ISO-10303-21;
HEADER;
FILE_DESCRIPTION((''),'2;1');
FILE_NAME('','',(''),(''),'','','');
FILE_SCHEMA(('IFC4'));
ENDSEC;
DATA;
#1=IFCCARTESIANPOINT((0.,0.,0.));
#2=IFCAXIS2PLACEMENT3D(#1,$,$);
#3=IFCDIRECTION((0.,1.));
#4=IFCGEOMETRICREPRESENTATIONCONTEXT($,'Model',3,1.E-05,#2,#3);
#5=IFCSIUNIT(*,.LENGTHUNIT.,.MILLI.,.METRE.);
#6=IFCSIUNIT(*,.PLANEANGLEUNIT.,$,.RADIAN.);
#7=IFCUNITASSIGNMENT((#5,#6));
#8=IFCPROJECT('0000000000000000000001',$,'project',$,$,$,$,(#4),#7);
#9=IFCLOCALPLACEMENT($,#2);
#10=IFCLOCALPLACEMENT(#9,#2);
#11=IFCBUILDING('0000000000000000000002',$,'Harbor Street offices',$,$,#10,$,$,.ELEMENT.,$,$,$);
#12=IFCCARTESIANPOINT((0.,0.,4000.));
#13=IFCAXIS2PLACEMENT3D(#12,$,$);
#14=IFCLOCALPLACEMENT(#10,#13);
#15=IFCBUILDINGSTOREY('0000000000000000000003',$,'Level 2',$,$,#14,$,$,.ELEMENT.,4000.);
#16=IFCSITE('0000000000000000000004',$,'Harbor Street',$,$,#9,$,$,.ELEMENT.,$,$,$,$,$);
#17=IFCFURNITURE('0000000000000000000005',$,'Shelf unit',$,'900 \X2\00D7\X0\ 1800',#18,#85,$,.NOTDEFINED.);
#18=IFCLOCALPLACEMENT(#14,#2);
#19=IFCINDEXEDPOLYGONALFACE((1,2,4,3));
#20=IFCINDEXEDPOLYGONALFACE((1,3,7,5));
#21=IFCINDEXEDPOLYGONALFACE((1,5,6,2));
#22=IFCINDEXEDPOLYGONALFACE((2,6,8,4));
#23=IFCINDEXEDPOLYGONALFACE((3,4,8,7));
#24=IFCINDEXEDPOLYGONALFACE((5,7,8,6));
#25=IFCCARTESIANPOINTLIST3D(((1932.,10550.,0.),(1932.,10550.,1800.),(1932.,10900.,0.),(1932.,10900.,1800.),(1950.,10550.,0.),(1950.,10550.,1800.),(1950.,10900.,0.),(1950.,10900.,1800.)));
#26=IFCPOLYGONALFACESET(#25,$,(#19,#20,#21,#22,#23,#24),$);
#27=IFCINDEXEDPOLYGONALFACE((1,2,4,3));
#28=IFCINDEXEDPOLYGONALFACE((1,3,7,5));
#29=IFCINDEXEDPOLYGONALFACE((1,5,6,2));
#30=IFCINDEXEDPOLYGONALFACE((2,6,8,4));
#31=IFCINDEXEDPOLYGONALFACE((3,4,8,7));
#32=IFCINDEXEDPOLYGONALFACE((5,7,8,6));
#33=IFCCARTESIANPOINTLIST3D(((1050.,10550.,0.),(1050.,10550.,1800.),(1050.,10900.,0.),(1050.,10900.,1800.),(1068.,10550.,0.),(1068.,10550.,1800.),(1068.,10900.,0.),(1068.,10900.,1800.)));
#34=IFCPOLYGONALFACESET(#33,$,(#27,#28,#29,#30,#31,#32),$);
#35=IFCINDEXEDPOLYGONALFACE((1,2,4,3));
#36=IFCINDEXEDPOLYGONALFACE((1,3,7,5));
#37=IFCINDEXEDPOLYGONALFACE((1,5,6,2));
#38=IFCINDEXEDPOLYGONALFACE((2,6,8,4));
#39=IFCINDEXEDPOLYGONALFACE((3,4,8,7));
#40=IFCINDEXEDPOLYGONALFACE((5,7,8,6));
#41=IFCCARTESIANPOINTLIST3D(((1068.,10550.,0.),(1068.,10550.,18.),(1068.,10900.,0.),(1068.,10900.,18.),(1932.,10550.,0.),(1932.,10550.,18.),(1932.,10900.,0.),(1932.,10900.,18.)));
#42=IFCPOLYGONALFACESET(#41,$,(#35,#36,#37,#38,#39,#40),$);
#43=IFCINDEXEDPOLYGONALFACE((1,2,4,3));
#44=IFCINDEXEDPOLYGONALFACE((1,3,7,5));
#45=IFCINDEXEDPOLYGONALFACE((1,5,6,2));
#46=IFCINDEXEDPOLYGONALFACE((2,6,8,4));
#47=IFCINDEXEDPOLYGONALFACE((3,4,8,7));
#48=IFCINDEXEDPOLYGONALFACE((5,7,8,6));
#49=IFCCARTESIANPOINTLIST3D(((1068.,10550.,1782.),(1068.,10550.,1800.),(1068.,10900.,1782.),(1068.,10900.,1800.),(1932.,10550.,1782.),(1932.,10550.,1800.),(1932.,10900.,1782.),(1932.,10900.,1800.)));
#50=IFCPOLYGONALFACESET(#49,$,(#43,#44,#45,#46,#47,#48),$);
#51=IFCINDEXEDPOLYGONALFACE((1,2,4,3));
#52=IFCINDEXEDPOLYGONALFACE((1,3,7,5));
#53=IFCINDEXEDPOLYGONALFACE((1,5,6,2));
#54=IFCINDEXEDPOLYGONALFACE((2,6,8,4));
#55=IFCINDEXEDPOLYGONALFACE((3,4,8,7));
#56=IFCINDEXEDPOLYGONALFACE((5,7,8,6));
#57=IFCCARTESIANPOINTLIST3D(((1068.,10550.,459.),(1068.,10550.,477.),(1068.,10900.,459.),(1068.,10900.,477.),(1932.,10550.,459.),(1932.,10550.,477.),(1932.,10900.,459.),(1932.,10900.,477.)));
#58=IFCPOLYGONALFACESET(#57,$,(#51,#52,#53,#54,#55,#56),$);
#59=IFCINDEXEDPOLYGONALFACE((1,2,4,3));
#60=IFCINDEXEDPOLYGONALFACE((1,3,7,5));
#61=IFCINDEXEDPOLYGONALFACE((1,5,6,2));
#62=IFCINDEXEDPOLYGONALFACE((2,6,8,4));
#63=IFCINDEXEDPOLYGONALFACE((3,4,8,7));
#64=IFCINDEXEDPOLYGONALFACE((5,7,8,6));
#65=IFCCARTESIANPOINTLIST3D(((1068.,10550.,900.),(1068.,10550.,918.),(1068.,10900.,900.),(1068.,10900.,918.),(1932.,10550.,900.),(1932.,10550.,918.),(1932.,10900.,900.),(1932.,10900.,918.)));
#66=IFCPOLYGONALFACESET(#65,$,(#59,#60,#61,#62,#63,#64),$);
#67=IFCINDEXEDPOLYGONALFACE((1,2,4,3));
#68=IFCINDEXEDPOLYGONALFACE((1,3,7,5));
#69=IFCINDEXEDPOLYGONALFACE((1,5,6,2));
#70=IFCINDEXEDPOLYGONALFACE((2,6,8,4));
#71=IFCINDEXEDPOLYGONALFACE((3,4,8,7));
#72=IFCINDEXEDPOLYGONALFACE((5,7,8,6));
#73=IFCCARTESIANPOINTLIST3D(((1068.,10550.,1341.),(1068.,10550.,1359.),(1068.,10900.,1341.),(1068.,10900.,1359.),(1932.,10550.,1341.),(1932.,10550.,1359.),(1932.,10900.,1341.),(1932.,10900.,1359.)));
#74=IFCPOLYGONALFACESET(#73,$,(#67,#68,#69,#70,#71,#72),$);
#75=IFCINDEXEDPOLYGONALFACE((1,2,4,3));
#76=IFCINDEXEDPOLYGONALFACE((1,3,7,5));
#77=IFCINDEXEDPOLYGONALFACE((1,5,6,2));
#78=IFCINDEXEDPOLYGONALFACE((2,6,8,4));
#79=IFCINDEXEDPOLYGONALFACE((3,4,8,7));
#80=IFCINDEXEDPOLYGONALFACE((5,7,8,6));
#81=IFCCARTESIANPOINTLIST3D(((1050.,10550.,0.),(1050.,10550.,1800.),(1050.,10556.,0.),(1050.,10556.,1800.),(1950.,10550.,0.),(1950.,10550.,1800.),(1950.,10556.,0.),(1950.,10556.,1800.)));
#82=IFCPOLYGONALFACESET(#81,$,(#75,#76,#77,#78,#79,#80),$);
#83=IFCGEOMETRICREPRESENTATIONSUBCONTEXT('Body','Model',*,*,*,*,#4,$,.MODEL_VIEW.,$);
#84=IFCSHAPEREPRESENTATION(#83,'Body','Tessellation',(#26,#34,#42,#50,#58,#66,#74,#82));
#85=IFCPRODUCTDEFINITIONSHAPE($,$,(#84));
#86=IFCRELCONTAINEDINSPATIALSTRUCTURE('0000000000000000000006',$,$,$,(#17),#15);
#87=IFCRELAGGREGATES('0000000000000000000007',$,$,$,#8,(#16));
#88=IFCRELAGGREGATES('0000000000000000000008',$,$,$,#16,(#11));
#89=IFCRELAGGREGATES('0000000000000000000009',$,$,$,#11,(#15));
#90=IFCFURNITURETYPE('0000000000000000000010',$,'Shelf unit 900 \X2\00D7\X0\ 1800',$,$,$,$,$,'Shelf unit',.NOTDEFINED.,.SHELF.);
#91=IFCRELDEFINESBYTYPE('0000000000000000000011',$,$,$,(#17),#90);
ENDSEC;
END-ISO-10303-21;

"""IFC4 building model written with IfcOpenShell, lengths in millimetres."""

from ifc_helpers import new_model, si_unit, direction, frame, origin, place, context, subcontext, project, spatial, polyline, outline, extrude, source, transform, mapped, type_object, type_shapes, element, save


model = new_model("IFC4")

# Units and contexts
model_context = context("Model", 3, precision=1e-05, world=origin(), true_north=direction((0.0, 1.0)))
body_context = subcontext(model_context, "Body", "Model", "MODEL_VIEW")
ifc_project = project(units=[si_unit("LENGTHUNIT", "METRE", prefix="MILLI"), si_unit("PLANEANGLEUNIT", "RADIAN")], contexts=[model_context])

# Site, building, storey
site_placement = place(None, origin())
site = spatial("IfcSite", under=ifc_project, at=site_placement, Name="Harbor Street", CompositionType="ELEMENT")
building_placement = place(site_placement, origin())
building = spatial("IfcBuilding", under=site, at=building_placement, Name="Harbor Street offices", CompositionType="ELEMENT")
storey_placement = place(building_placement, frame((0.0, 0.0, 4000.0)))
storey = spatial("IfcBuildingStorey", under=building, at=storey_placement, Name="Level 2", CompositionType="ELEMENT", Elevation=4000.0)

# Furniture
furniture_type_1 = type_object("IfcFurnitureType", Name="Shelf unit 900 × 1800", ElementType="Shelf unit", AssemblyPlace="NOTDEFINED", PredefinedType="SHELF")
shared_shape_1 = source(origin(), body_context, "Body", "SweptSolid", [
    extrude(outline(polyline([(-450.0, 0.0), (-432.0, 0.0), (-432.0, 350.0), (-450.0, 350.0), (-450.0, 0.0)])), origin(), (0.0, 0.0, 1.0), 1800.0),
    extrude(outline(polyline([(432.0, 0.0), (450.0, 0.0), (450.0, 350.0), (432.0, 350.0), (432.0, 0.0)])), origin(), (0.0, 0.0, 1.0), 1800.0),
    extrude(outline(polyline([(-432.0, 0.0), (432.0, 0.0), (432.0, 350.0), (-432.0, 350.0), (-432.0, 0.0)])), origin(), (0.0, 0.0, 1.0), 18.0),
    extrude(outline(polyline([(-432.0, 0.0), (432.0, 0.0), (432.0, 350.0), (-432.0, 350.0), (-432.0, 0.0)])), frame((0.0, 0.0, 1782.0)), (0.0, 0.0, 1.0), 18.0),
    extrude(outline(polyline([(-432.0, 0.0), (432.0, 0.0), (432.0, 350.0), (-432.0, 350.0), (-432.0, 0.0)])), frame((0.0, 0.0, 459.0)), (0.0, 0.0, 1.0), 18.0),
    extrude(outline(polyline([(-432.0, 0.0), (432.0, 0.0), (432.0, 350.0), (-432.0, 350.0), (-432.0, 0.0)])), frame((0.0, 0.0, 900.0)), (0.0, 0.0, 1.0), 18.0),
    extrude(outline(polyline([(-432.0, 0.0), (432.0, 0.0), (432.0, 350.0), (-432.0, 350.0), (-432.0, 0.0)])), frame((0.0, 0.0, 1341.0)), (0.0, 0.0, 1.0), 18.0),
    extrude(outline(polyline([(-450.0, 344.0), (450.0, 344.0), (450.0, 350.0), (-450.0, 350.0), (-450.0, 344.0)])), origin(), (0.0, 0.0, 1.0), 1800.0),
])
type_shapes(furniture_type_1, [shared_shape_1])
for number, where, z_axis, x_axis, name in (
    (1, (1500.0, 10900.0, 0.0), (0.0, 0.0, 1.0), (-1.0, 0.0, 0.0), "Shelf unit"),
):
    element("IfcFurniture", number, at=place(storey_placement, frame(where, z_axis=z_axis, x_axis=x_axis)), inside=storey, type_object=furniture_type_1, Name=name, ObjectType="900 × 1800", PredefinedType="NOTDEFINED", context=body_context, shape_type="MappedRepresentation", body=[
        mapped(shared_shape_1, transform((0.0, 0.0, 0.0))),
    ])

save(model, "model.ifc")
